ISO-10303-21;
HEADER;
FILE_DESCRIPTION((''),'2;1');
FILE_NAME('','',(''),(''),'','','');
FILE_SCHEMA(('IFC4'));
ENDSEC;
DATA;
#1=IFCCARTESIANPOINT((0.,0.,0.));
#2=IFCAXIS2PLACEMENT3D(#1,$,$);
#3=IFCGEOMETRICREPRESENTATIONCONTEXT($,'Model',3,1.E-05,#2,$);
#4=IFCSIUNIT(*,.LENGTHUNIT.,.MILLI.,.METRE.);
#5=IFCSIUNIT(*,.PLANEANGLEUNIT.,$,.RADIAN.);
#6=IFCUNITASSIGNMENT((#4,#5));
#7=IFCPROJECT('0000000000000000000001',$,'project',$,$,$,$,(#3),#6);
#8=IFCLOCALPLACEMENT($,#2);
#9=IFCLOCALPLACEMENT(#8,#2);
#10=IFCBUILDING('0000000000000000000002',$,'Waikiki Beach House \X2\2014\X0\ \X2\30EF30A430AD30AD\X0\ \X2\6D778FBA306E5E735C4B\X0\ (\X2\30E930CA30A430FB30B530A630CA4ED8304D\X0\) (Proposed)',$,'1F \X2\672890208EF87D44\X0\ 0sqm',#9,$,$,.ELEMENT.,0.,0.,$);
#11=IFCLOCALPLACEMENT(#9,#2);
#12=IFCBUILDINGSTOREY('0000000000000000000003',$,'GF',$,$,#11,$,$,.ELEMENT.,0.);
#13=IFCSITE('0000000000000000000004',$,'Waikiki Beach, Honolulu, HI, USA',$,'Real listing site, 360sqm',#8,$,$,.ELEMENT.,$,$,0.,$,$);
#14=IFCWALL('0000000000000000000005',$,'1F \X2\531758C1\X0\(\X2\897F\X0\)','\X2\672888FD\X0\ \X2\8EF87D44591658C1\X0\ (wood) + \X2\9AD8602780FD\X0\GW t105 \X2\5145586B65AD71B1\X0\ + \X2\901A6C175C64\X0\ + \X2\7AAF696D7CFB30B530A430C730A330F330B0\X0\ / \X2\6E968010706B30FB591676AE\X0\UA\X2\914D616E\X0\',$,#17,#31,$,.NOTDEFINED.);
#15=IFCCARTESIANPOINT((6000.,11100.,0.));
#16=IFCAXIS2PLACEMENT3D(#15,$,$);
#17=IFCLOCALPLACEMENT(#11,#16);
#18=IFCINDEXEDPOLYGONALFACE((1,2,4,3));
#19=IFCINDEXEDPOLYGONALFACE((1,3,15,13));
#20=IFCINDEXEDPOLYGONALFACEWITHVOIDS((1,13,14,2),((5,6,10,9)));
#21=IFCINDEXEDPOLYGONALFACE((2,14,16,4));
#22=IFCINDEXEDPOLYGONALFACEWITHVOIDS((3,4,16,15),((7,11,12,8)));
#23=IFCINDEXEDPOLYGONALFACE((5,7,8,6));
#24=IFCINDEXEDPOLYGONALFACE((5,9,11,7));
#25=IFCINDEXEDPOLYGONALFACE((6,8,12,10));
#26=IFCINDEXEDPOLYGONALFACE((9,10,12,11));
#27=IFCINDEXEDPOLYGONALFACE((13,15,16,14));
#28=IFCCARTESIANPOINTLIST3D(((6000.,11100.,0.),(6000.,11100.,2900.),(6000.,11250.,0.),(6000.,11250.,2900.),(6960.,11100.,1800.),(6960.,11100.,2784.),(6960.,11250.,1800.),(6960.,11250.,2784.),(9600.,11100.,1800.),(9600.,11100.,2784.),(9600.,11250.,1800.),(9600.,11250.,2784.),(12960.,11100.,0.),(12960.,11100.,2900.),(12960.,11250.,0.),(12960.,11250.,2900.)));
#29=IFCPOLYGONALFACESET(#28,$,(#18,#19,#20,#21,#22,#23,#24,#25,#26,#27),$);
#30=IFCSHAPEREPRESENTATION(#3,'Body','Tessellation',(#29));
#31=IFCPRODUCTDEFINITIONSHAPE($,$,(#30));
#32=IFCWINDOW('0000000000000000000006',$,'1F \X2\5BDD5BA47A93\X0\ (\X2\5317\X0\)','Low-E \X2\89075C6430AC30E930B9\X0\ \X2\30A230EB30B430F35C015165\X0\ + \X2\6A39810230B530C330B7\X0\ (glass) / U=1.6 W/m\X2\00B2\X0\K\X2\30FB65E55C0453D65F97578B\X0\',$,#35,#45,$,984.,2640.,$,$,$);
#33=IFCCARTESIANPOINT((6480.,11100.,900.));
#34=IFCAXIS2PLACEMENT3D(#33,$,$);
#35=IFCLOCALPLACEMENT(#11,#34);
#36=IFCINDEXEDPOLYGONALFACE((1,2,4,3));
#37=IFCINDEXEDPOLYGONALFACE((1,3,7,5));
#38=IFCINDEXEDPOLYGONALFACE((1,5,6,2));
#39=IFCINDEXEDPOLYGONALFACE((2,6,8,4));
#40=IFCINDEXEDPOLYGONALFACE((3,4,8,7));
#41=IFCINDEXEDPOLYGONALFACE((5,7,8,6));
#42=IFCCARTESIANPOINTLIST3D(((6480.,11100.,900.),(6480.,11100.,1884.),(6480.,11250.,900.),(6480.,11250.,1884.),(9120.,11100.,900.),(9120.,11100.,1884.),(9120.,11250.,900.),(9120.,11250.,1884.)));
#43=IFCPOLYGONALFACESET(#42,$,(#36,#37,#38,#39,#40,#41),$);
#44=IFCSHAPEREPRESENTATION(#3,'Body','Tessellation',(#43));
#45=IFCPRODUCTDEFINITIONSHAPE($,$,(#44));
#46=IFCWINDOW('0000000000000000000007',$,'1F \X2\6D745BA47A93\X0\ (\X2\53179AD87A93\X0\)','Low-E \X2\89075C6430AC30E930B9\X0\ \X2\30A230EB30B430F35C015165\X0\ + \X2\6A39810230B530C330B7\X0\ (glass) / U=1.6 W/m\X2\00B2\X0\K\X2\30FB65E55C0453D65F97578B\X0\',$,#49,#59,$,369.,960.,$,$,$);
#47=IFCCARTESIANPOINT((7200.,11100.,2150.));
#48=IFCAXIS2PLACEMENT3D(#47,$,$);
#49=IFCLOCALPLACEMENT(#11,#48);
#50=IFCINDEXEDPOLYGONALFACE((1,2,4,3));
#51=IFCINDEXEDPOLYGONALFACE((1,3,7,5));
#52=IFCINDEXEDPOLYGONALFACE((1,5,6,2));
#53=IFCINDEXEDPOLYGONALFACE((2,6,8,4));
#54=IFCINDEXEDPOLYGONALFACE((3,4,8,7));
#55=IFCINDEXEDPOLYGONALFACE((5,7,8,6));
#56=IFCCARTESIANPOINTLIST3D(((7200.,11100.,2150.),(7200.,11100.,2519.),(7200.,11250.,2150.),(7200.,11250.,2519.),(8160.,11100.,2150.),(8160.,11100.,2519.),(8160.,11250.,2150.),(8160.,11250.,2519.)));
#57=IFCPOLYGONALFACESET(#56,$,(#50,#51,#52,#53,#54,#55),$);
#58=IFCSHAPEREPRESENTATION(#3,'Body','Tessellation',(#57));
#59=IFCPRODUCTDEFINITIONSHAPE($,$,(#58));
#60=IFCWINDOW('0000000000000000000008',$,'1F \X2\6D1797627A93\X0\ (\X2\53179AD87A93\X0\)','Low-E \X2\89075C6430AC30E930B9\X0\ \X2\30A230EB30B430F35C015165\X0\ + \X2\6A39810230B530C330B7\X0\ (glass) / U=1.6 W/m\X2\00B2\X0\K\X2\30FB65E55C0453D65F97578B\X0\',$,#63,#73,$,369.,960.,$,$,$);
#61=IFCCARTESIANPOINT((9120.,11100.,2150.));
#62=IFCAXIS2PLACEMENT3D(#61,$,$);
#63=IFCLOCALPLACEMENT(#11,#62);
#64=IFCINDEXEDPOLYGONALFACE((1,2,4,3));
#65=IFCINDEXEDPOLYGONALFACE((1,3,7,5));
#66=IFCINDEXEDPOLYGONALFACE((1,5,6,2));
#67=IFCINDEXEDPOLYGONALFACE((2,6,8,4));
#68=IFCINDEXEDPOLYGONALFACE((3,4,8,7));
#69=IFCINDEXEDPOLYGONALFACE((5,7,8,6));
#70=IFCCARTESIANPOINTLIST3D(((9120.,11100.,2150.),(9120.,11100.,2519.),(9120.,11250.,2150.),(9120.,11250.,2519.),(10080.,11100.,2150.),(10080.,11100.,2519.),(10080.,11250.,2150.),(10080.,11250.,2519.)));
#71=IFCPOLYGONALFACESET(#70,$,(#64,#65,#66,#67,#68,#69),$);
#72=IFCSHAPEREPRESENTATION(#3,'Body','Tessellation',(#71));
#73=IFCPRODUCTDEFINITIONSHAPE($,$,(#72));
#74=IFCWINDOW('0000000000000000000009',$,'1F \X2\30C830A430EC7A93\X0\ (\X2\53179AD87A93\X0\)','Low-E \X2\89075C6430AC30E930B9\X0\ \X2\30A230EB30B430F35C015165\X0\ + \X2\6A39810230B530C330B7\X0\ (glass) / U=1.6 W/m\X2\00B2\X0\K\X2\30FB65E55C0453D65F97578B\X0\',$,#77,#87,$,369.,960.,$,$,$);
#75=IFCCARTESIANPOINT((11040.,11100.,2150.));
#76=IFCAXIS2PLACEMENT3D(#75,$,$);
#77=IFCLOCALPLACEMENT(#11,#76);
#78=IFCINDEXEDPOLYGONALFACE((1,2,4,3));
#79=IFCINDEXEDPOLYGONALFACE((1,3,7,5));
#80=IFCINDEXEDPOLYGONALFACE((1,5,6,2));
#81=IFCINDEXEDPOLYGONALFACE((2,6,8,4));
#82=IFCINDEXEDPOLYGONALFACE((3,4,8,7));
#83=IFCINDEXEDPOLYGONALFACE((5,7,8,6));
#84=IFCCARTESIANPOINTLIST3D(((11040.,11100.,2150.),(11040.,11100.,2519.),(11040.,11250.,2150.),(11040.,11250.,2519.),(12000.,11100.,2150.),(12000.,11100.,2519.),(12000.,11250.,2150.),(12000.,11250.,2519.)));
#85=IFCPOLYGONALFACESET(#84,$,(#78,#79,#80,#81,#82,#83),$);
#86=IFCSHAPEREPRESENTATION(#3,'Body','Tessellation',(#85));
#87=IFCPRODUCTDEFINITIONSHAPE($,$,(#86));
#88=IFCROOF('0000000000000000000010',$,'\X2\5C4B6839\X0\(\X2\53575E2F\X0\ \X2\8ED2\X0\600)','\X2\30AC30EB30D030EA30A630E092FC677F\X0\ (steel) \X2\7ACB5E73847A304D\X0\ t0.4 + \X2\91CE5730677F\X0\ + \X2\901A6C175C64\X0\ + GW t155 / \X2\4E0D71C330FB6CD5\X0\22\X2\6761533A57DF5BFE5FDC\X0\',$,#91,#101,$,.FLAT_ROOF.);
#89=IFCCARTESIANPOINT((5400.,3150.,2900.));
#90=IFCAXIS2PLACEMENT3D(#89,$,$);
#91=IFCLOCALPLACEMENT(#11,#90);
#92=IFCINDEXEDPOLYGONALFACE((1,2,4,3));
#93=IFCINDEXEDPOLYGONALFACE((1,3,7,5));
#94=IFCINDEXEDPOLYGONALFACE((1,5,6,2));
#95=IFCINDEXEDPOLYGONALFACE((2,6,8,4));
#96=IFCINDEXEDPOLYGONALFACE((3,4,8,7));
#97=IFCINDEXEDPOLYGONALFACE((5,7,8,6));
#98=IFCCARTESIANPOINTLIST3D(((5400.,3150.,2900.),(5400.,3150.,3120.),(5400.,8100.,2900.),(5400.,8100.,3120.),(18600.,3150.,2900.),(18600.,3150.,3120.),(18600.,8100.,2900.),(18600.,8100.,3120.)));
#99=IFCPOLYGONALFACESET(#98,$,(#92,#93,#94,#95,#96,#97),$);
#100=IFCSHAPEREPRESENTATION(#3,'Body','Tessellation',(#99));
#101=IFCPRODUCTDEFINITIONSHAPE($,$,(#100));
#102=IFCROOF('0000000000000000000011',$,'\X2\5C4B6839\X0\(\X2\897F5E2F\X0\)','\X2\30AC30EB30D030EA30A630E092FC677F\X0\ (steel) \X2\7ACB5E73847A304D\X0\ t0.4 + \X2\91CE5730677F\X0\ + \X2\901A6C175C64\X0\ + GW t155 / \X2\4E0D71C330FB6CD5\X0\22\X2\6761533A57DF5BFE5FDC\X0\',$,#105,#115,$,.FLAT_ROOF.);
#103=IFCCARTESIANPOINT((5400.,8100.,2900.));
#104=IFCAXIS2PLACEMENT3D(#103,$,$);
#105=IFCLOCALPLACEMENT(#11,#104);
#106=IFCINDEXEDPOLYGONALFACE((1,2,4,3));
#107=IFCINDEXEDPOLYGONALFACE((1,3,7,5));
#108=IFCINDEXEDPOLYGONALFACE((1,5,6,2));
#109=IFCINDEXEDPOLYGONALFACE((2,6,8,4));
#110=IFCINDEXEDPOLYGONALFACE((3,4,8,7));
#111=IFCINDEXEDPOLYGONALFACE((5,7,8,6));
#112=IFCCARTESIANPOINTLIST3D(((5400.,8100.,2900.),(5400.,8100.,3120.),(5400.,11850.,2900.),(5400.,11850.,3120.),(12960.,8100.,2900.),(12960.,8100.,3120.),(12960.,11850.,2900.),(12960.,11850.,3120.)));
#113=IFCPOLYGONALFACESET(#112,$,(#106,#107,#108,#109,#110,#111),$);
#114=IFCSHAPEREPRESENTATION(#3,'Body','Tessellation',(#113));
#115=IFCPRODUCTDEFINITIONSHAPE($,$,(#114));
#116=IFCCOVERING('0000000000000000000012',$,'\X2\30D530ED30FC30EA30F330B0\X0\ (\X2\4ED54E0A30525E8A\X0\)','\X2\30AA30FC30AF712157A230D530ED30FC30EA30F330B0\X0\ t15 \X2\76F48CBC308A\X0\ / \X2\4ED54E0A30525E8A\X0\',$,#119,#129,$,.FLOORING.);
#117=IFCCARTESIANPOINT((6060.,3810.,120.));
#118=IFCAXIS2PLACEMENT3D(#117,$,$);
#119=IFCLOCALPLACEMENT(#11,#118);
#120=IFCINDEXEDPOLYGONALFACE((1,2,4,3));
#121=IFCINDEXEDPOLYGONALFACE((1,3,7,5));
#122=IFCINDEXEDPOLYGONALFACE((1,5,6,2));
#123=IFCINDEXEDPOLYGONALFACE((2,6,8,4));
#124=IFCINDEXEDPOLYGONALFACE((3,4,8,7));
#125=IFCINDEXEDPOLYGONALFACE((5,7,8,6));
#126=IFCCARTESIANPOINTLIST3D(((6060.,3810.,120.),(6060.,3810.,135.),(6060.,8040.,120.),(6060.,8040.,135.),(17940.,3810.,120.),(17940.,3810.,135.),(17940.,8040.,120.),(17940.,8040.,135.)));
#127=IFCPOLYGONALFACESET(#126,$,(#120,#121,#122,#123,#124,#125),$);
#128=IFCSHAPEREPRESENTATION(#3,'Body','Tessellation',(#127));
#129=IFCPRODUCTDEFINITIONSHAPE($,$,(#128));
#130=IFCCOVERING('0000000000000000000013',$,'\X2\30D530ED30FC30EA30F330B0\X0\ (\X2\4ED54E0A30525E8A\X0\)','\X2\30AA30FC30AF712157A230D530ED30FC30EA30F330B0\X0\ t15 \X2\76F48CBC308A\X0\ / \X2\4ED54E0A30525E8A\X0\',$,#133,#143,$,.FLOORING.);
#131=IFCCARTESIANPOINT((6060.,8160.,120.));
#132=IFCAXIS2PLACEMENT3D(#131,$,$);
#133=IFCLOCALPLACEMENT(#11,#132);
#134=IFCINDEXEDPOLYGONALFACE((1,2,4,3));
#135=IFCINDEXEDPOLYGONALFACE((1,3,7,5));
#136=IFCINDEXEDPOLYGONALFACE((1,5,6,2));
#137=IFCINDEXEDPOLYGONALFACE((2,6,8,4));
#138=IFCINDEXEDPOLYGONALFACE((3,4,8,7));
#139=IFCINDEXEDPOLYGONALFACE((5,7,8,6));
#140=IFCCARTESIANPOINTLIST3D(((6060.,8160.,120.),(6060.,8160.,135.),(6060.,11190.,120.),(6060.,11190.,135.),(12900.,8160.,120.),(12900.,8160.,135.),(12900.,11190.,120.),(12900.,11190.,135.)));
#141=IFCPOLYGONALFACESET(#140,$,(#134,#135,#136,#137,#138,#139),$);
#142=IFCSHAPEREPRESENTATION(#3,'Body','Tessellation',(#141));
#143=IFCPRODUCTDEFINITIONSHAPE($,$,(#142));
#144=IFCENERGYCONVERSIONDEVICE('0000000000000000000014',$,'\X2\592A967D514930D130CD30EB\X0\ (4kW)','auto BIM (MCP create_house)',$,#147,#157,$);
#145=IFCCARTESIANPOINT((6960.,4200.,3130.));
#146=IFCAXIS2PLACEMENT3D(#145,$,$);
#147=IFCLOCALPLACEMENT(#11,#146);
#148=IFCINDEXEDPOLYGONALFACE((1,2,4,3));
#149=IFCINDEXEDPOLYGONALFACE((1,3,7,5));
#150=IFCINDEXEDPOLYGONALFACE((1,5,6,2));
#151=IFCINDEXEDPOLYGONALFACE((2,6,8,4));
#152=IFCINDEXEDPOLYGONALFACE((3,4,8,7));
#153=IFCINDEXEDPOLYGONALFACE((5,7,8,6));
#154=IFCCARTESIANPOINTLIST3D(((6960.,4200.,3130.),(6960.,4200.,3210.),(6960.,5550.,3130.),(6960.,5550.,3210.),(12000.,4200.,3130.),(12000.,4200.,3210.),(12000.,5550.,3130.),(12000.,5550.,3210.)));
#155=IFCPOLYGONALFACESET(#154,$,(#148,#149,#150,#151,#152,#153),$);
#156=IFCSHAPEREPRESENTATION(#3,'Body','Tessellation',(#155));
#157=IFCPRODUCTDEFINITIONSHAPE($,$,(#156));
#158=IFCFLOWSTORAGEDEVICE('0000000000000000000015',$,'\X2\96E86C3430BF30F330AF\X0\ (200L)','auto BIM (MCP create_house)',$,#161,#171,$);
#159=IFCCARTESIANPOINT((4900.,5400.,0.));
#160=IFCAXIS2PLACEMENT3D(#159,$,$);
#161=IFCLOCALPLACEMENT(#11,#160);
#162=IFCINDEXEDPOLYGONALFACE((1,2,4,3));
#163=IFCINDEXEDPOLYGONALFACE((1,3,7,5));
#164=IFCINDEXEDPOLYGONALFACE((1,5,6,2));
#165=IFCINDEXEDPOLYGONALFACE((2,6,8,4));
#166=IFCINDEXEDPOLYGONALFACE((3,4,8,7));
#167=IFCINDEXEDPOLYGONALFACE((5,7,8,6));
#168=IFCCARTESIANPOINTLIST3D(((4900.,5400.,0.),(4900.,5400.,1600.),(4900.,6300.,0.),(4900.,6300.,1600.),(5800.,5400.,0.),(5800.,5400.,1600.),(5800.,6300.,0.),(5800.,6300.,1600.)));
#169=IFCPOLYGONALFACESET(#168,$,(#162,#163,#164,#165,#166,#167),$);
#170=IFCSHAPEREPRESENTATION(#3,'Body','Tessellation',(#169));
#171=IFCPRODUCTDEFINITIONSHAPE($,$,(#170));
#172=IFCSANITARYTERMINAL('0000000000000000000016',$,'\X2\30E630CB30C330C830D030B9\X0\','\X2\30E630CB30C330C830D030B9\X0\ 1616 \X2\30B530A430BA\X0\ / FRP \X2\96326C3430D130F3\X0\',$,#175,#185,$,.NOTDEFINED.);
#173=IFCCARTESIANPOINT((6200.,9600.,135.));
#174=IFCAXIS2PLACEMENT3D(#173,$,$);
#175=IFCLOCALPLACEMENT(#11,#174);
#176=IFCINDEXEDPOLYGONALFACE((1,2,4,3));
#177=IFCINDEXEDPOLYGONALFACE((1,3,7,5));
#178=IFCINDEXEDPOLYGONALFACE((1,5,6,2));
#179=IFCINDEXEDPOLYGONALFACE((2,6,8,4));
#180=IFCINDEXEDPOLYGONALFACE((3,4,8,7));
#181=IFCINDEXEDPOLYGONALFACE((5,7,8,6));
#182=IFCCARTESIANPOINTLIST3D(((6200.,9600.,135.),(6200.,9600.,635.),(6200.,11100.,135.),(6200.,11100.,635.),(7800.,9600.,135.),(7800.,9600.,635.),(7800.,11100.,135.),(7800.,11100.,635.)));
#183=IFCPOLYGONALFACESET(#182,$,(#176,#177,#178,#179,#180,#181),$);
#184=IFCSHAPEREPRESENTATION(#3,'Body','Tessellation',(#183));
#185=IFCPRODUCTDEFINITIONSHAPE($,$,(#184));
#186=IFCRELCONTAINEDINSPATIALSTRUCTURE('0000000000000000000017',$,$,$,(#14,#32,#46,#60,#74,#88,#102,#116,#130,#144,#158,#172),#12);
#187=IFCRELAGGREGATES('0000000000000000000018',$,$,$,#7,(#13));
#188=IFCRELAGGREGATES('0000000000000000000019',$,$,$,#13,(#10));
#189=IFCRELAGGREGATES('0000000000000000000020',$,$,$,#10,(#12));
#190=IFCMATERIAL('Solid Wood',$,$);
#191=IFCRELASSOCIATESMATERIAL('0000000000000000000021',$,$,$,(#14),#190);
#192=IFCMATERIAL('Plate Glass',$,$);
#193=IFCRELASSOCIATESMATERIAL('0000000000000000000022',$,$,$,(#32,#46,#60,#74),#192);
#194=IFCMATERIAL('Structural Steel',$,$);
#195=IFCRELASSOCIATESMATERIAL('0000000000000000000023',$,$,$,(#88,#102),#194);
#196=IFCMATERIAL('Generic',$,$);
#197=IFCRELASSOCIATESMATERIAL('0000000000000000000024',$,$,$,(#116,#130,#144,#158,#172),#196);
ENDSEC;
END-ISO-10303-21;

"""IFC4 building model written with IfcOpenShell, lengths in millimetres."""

from ifc_helpers import new_model, si_unit, frame, frame_2d, origin, place, context, project, spatial, rectangle, extrude, material, element, fill, save


model = new_model("IFC4")

# Units and contexts
model_context = context("Model", 3, precision=1e-05, world=origin())
ifc_project = project(units=[si_unit("LENGTHUNIT", "METRE", prefix="MILLI"), si_unit("PLANEANGLEUNIT", "RADIAN")], contexts=[model_context])

# Site, building, storey
site_placement = place(None, origin())
site = spatial("IfcSite", under=ifc_project, at=site_placement, Name="Waikiki Beach, Honolulu, HI, USA", ObjectType="Real listing site, 360sqm", CompositionType="ELEMENT", RefElevation=0.0)
building_placement = place(site_placement, origin())
building = spatial("IfcBuilding", under=site, at=building_placement, Name="Waikiki Beach House — ワイキキ 海辺の平屋 (ラナイ・サウナ付き) (Proposed)", ObjectType="1F 木造軸組 0sqm", CompositionType="ELEMENT", ElevationOfRefHeight=0.0, ElevationOfTerrain=0.0)
storey_placement = place(building_placement, origin())
storey = spatial("IfcBuildingStorey", under=building, at=storey_placement, Name="GF", CompositionType="ELEMENT", Elevation=0.0)

# Shared definitions
ifc_material_1 = material(Name="Solid Wood")

# Shared definitions
ifc_material_2 = material(Name="Plate Glass")

# Wall, openings, windows
wall_1_placement = place(storey_placement, frame((6000.0, 11100.0, 0.0)))
wall_1 = element("IfcWall", 1, at=wall_1_placement, inside=storey, material=ifc_material_1, Name="1F 北壁(西)", Description="木製 軸組外壁 (wood) + 高性能GW t105 充填断熱 + 通気層 + 窯業系サイディング / 準耐火・外皮UA配慮", PredefinedType="NOTDEFINED", context=model_context, shape_type="SweptSolid", body=[
    extrude(rectangle(XDim=6960.0, YDim=150.0, at=frame_2d((3480.0, 75.0))), frame((6000.0, 11100.0, 0.0)), (0.0, 0.0, 1.0), 2900.0),
])
opening_1_placement = place(storey_placement, frame((6480.0, 11100.0, 900.0)))
opening_1 = element("IfcOpeningElement", 2, at=opening_1_placement, cuts=wall_1, PredefinedType="NOTDEFINED", context=model_context, shape_type="SweptSolid", body=[
    extrude(rectangle(XDim=2640.0, YDim=150.0, at=frame_2d((1320.0, 75.0))), frame((6480.0, 11100.0, 900.0)), (0.0, 0.0, 1.0), 984.0),
])
opening_2_placement = place(storey_placement, frame((7200.0, 11100.0, 2150.0)))
opening_2 = element("IfcOpeningElement", 3, at=opening_2_placement, cuts=wall_1, PredefinedType="NOTDEFINED", context=model_context, shape_type="SweptSolid", body=[
    extrude(rectangle(XDim=960.0, YDim=150.0, at=frame_2d((480.0, 75.0))), frame((7200.0, 11100.0, 2150.0)), (0.0, 0.0, 1.0), 369.0),
])
opening_3_placement = place(storey_placement, frame((9120.0, 11100.0, 2150.0)))
opening_3 = element("IfcOpeningElement", 4, at=opening_3_placement, cuts=wall_1, PredefinedType="NOTDEFINED", context=model_context, shape_type="SweptSolid", body=[
    extrude(rectangle(XDim=960.0, YDim=150.0, at=frame_2d((480.0, 75.0))), frame((9120.0, 11100.0, 2150.0)), (0.0, 0.0, 1.0), 369.0),
])
opening_4_placement = place(storey_placement, frame((11040.0, 11100.0, 2150.0)))
opening_4 = element("IfcOpeningElement", 5, at=opening_4_placement, cuts=wall_1, PredefinedType="NOTDEFINED", context=model_context, shape_type="SweptSolid", body=[
    extrude(rectangle(XDim=960.0, YDim=150.0, at=frame_2d((480.0, 75.0))), frame((11040.0, 11100.0, 2150.0)), (0.0, 0.0, 1.0), 369.0),
])
window_1_placement = place(storey_placement, frame((6480.0, 11100.0, 900.0)))
window_1 = element("IfcWindow", 6, at=window_1_placement, inside=storey, material=ifc_material_2, Name="1F 寝室窓 (北)", Description="Low-E 複層ガラス アルゴン封入 + 樹脂サッシ (glass) / U=1.6 W/m²K・日射取得型", OverallHeight=984.0, OverallWidth=2640.0, context=model_context, shape_type="SweptSolid", body=[
    extrude(rectangle(XDim=2640.0, YDim=150.0, at=frame_2d((1320.0, 75.0))), frame((6480.0, 11100.0, 900.0)), (0.0, 0.0, 1.0), 984.0),
])
fill(opening_1, window_1)
window_2_placement = place(storey_placement, frame((7200.0, 11100.0, 2150.0)))
window_2 = element("IfcWindow", 7, at=window_2_placement, inside=storey, material=ifc_material_2, Name="1F 浴室窓 (北高窓)", Description="Low-E 複層ガラス アルゴン封入 + 樹脂サッシ (glass) / U=1.6 W/m²K・日射取得型", OverallHeight=369.0, OverallWidth=960.0, context=model_context, shape_type="SweptSolid", body=[
    extrude(rectangle(XDim=960.0, YDim=150.0, at=frame_2d((480.0, 75.0))), frame((7200.0, 11100.0, 2150.0)), (0.0, 0.0, 1.0), 369.0),
])
fill(opening_2, window_2)
window_3_placement = place(storey_placement, frame((9120.0, 11100.0, 2150.0)))
window_3 = element("IfcWindow", 8, at=window_3_placement, inside=storey, material=ifc_material_2, Name="1F 洗面窓 (北高窓)", Description="Low-E 複層ガラス アルゴン封入 + 樹脂サッシ (glass) / U=1.6 W/m²K・日射取得型", OverallHeight=369.0, OverallWidth=960.0, context=model_context, shape_type="SweptSolid", body=[
    extrude(rectangle(XDim=960.0, YDim=150.0, at=frame_2d((480.0, 75.0))), frame((9120.0, 11100.0, 2150.0)), (0.0, 0.0, 1.0), 369.0),
])
fill(opening_3, window_3)
window_4_placement = place(storey_placement, frame((11040.0, 11100.0, 2150.0)))
window_4 = element("IfcWindow", 9, at=window_4_placement, inside=storey, material=ifc_material_2, Name="1F トイレ窓 (北高窓)", Description="Low-E 複層ガラス アルゴン封入 + 樹脂サッシ (glass) / U=1.6 W/m²K・日射取得型", OverallHeight=369.0, OverallWidth=960.0, context=model_context, shape_type="SweptSolid", body=[
    extrude(rectangle(XDim=960.0, YDim=150.0, at=frame_2d((480.0, 75.0))), frame((11040.0, 11100.0, 2150.0)), (0.0, 0.0, 1.0), 369.0),
])
fill(opening_4, window_4)

# Roofs
ifc_material_3 = material(Name="Structural Steel")
roof_1_placement = place(storey_placement, frame((5400.0, 3150.0, 2900.0)))
element("IfcRoof", 10, at=roof_1_placement, inside=storey, material=ifc_material_3, Name="屋根(南帯 軒600)", Description="ガルバリウム鋼板 (steel) 立平葺き t0.4 + 野地板 + 通気層 + GW t155 / 不燃・法22条区域対応", PredefinedType="FLAT_ROOF", context=model_context, shape_type="SweptSolid", body=[
    extrude(rectangle(XDim=13200.0, YDim=4950.0, at=frame_2d((6600.0, 2475.0))), frame((5400.0, 3150.0, 2900.0)), (0.0, 0.0, 1.0), 220.0),
])
roof_2_placement = place(storey_placement, frame((5400.0, 8100.0, 2900.0)))
element("IfcRoof", 11, at=roof_2_placement, inside=storey, material=ifc_material_3, Name="屋根(西帯)", Description="ガルバリウム鋼板 (steel) 立平葺き t0.4 + 野地板 + 通気層 + GW t155 / 不燃・法22条区域対応", PredefinedType="FLAT_ROOF", context=model_context, shape_type="SweptSolid", body=[
    extrude(rectangle(XDim=7560.0, YDim=3750.0, at=frame_2d((3780.0, 1875.0))), frame((5400.0, 8100.0, 2900.0)), (0.0, 0.0, 1.0), 220.0),
])

# Coverings
ifc_material_4 = material(Name="Generic")
covering_1_placement = place(storey_placement, frame((6060.0, 3810.0, 120.0)))
element("IfcCovering", 12, at=covering_1_placement, inside=storey, material=ifc_material_4, Name="フローリング (仕上げ床)", Description="オーク無垢フローリング t15 直貼り / 仕上げ床", PredefinedType="FLOORING", context=model_context, shape_type="SweptSolid", body=[
    extrude(rectangle(XDim=11880.0, YDim=4230.0, at=frame_2d((5940.0, 2115.0))), frame((6060.0, 3810.0, 120.0)), (0.0, 0.0, 1.0), 15.0),
])
covering_2_placement = place(storey_placement, frame((6060.0, 8160.0, 120.0)))
element("IfcCovering", 13, at=covering_2_placement, inside=storey, material=ifc_material_4, Name="フローリング (仕上げ床)", Description="オーク無垢フローリング t15 直貼り / 仕上げ床", PredefinedType="FLOORING", context=model_context, shape_type="SweptSolid", body=[
    extrude(rectangle(XDim=6840.0, YDim=3030.0, at=frame_2d((3420.0, 1515.0))), frame((6060.0, 8160.0, 120.0)), (0.0, 0.0, 1.0), 15.0),
])

# Energy conversion device
energy_conversion_device_placement = place(storey_placement, frame((6960.0, 4200.0, 3130.0)))
element("IfcEnergyConversionDevice", 14, at=energy_conversion_device_placement, inside=storey, material=ifc_material_4, Name="太陽光パネル (4kW)", Description="auto BIM (MCP create_house)", context=model_context, shape_type="SweptSolid", body=[
    extrude(rectangle(XDim=5040.0, YDim=1350.0, at=frame_2d((2520.0, 675.0))), frame((6960.0, 4200.0, 3130.0)), (0.0, 0.0, 1.0), 80.0),
])

# Flow storage device
flow_storage_device_placement = place(storey_placement, frame((4900.0, 5400.0, 0.0)))
element("IfcFlowStorageDevice", 15, at=flow_storage_device_placement, inside=storey, material=ifc_material_4, Name="雨水タンク (200L)", Description="auto BIM (MCP create_house)", context=model_context, shape_type="SweptSolid", body=[
    extrude(rectangle(XDim=900.0, YDim=900.0, at=frame_2d((450.0, 450.0))), frame((4900.0, 5400.0, 0.0)), (0.0, 0.0, 1.0), 1600.0),
])

# Sanitary terminal
sanitary_terminal_placement = place(storey_placement, frame((6200.0, 9600.0, 135.0)))
element("IfcSanitaryTerminal", 16, at=sanitary_terminal_placement, inside=storey, material=ifc_material_4, Name="ユニットバス", Description="ユニットバス 1616 サイズ / FRP 防水パン", PredefinedType="NOTDEFINED", context=model_context, shape_type="SweptSolid", body=[
    extrude(rectangle(XDim=1600.0, YDim=1500.0, at=frame_2d((800.0, 750.0))), frame((6200.0, 9600.0, 135.0)), (0.0, 0.0, 1.0), 500.0),
])

save(model, "model.ifc")
